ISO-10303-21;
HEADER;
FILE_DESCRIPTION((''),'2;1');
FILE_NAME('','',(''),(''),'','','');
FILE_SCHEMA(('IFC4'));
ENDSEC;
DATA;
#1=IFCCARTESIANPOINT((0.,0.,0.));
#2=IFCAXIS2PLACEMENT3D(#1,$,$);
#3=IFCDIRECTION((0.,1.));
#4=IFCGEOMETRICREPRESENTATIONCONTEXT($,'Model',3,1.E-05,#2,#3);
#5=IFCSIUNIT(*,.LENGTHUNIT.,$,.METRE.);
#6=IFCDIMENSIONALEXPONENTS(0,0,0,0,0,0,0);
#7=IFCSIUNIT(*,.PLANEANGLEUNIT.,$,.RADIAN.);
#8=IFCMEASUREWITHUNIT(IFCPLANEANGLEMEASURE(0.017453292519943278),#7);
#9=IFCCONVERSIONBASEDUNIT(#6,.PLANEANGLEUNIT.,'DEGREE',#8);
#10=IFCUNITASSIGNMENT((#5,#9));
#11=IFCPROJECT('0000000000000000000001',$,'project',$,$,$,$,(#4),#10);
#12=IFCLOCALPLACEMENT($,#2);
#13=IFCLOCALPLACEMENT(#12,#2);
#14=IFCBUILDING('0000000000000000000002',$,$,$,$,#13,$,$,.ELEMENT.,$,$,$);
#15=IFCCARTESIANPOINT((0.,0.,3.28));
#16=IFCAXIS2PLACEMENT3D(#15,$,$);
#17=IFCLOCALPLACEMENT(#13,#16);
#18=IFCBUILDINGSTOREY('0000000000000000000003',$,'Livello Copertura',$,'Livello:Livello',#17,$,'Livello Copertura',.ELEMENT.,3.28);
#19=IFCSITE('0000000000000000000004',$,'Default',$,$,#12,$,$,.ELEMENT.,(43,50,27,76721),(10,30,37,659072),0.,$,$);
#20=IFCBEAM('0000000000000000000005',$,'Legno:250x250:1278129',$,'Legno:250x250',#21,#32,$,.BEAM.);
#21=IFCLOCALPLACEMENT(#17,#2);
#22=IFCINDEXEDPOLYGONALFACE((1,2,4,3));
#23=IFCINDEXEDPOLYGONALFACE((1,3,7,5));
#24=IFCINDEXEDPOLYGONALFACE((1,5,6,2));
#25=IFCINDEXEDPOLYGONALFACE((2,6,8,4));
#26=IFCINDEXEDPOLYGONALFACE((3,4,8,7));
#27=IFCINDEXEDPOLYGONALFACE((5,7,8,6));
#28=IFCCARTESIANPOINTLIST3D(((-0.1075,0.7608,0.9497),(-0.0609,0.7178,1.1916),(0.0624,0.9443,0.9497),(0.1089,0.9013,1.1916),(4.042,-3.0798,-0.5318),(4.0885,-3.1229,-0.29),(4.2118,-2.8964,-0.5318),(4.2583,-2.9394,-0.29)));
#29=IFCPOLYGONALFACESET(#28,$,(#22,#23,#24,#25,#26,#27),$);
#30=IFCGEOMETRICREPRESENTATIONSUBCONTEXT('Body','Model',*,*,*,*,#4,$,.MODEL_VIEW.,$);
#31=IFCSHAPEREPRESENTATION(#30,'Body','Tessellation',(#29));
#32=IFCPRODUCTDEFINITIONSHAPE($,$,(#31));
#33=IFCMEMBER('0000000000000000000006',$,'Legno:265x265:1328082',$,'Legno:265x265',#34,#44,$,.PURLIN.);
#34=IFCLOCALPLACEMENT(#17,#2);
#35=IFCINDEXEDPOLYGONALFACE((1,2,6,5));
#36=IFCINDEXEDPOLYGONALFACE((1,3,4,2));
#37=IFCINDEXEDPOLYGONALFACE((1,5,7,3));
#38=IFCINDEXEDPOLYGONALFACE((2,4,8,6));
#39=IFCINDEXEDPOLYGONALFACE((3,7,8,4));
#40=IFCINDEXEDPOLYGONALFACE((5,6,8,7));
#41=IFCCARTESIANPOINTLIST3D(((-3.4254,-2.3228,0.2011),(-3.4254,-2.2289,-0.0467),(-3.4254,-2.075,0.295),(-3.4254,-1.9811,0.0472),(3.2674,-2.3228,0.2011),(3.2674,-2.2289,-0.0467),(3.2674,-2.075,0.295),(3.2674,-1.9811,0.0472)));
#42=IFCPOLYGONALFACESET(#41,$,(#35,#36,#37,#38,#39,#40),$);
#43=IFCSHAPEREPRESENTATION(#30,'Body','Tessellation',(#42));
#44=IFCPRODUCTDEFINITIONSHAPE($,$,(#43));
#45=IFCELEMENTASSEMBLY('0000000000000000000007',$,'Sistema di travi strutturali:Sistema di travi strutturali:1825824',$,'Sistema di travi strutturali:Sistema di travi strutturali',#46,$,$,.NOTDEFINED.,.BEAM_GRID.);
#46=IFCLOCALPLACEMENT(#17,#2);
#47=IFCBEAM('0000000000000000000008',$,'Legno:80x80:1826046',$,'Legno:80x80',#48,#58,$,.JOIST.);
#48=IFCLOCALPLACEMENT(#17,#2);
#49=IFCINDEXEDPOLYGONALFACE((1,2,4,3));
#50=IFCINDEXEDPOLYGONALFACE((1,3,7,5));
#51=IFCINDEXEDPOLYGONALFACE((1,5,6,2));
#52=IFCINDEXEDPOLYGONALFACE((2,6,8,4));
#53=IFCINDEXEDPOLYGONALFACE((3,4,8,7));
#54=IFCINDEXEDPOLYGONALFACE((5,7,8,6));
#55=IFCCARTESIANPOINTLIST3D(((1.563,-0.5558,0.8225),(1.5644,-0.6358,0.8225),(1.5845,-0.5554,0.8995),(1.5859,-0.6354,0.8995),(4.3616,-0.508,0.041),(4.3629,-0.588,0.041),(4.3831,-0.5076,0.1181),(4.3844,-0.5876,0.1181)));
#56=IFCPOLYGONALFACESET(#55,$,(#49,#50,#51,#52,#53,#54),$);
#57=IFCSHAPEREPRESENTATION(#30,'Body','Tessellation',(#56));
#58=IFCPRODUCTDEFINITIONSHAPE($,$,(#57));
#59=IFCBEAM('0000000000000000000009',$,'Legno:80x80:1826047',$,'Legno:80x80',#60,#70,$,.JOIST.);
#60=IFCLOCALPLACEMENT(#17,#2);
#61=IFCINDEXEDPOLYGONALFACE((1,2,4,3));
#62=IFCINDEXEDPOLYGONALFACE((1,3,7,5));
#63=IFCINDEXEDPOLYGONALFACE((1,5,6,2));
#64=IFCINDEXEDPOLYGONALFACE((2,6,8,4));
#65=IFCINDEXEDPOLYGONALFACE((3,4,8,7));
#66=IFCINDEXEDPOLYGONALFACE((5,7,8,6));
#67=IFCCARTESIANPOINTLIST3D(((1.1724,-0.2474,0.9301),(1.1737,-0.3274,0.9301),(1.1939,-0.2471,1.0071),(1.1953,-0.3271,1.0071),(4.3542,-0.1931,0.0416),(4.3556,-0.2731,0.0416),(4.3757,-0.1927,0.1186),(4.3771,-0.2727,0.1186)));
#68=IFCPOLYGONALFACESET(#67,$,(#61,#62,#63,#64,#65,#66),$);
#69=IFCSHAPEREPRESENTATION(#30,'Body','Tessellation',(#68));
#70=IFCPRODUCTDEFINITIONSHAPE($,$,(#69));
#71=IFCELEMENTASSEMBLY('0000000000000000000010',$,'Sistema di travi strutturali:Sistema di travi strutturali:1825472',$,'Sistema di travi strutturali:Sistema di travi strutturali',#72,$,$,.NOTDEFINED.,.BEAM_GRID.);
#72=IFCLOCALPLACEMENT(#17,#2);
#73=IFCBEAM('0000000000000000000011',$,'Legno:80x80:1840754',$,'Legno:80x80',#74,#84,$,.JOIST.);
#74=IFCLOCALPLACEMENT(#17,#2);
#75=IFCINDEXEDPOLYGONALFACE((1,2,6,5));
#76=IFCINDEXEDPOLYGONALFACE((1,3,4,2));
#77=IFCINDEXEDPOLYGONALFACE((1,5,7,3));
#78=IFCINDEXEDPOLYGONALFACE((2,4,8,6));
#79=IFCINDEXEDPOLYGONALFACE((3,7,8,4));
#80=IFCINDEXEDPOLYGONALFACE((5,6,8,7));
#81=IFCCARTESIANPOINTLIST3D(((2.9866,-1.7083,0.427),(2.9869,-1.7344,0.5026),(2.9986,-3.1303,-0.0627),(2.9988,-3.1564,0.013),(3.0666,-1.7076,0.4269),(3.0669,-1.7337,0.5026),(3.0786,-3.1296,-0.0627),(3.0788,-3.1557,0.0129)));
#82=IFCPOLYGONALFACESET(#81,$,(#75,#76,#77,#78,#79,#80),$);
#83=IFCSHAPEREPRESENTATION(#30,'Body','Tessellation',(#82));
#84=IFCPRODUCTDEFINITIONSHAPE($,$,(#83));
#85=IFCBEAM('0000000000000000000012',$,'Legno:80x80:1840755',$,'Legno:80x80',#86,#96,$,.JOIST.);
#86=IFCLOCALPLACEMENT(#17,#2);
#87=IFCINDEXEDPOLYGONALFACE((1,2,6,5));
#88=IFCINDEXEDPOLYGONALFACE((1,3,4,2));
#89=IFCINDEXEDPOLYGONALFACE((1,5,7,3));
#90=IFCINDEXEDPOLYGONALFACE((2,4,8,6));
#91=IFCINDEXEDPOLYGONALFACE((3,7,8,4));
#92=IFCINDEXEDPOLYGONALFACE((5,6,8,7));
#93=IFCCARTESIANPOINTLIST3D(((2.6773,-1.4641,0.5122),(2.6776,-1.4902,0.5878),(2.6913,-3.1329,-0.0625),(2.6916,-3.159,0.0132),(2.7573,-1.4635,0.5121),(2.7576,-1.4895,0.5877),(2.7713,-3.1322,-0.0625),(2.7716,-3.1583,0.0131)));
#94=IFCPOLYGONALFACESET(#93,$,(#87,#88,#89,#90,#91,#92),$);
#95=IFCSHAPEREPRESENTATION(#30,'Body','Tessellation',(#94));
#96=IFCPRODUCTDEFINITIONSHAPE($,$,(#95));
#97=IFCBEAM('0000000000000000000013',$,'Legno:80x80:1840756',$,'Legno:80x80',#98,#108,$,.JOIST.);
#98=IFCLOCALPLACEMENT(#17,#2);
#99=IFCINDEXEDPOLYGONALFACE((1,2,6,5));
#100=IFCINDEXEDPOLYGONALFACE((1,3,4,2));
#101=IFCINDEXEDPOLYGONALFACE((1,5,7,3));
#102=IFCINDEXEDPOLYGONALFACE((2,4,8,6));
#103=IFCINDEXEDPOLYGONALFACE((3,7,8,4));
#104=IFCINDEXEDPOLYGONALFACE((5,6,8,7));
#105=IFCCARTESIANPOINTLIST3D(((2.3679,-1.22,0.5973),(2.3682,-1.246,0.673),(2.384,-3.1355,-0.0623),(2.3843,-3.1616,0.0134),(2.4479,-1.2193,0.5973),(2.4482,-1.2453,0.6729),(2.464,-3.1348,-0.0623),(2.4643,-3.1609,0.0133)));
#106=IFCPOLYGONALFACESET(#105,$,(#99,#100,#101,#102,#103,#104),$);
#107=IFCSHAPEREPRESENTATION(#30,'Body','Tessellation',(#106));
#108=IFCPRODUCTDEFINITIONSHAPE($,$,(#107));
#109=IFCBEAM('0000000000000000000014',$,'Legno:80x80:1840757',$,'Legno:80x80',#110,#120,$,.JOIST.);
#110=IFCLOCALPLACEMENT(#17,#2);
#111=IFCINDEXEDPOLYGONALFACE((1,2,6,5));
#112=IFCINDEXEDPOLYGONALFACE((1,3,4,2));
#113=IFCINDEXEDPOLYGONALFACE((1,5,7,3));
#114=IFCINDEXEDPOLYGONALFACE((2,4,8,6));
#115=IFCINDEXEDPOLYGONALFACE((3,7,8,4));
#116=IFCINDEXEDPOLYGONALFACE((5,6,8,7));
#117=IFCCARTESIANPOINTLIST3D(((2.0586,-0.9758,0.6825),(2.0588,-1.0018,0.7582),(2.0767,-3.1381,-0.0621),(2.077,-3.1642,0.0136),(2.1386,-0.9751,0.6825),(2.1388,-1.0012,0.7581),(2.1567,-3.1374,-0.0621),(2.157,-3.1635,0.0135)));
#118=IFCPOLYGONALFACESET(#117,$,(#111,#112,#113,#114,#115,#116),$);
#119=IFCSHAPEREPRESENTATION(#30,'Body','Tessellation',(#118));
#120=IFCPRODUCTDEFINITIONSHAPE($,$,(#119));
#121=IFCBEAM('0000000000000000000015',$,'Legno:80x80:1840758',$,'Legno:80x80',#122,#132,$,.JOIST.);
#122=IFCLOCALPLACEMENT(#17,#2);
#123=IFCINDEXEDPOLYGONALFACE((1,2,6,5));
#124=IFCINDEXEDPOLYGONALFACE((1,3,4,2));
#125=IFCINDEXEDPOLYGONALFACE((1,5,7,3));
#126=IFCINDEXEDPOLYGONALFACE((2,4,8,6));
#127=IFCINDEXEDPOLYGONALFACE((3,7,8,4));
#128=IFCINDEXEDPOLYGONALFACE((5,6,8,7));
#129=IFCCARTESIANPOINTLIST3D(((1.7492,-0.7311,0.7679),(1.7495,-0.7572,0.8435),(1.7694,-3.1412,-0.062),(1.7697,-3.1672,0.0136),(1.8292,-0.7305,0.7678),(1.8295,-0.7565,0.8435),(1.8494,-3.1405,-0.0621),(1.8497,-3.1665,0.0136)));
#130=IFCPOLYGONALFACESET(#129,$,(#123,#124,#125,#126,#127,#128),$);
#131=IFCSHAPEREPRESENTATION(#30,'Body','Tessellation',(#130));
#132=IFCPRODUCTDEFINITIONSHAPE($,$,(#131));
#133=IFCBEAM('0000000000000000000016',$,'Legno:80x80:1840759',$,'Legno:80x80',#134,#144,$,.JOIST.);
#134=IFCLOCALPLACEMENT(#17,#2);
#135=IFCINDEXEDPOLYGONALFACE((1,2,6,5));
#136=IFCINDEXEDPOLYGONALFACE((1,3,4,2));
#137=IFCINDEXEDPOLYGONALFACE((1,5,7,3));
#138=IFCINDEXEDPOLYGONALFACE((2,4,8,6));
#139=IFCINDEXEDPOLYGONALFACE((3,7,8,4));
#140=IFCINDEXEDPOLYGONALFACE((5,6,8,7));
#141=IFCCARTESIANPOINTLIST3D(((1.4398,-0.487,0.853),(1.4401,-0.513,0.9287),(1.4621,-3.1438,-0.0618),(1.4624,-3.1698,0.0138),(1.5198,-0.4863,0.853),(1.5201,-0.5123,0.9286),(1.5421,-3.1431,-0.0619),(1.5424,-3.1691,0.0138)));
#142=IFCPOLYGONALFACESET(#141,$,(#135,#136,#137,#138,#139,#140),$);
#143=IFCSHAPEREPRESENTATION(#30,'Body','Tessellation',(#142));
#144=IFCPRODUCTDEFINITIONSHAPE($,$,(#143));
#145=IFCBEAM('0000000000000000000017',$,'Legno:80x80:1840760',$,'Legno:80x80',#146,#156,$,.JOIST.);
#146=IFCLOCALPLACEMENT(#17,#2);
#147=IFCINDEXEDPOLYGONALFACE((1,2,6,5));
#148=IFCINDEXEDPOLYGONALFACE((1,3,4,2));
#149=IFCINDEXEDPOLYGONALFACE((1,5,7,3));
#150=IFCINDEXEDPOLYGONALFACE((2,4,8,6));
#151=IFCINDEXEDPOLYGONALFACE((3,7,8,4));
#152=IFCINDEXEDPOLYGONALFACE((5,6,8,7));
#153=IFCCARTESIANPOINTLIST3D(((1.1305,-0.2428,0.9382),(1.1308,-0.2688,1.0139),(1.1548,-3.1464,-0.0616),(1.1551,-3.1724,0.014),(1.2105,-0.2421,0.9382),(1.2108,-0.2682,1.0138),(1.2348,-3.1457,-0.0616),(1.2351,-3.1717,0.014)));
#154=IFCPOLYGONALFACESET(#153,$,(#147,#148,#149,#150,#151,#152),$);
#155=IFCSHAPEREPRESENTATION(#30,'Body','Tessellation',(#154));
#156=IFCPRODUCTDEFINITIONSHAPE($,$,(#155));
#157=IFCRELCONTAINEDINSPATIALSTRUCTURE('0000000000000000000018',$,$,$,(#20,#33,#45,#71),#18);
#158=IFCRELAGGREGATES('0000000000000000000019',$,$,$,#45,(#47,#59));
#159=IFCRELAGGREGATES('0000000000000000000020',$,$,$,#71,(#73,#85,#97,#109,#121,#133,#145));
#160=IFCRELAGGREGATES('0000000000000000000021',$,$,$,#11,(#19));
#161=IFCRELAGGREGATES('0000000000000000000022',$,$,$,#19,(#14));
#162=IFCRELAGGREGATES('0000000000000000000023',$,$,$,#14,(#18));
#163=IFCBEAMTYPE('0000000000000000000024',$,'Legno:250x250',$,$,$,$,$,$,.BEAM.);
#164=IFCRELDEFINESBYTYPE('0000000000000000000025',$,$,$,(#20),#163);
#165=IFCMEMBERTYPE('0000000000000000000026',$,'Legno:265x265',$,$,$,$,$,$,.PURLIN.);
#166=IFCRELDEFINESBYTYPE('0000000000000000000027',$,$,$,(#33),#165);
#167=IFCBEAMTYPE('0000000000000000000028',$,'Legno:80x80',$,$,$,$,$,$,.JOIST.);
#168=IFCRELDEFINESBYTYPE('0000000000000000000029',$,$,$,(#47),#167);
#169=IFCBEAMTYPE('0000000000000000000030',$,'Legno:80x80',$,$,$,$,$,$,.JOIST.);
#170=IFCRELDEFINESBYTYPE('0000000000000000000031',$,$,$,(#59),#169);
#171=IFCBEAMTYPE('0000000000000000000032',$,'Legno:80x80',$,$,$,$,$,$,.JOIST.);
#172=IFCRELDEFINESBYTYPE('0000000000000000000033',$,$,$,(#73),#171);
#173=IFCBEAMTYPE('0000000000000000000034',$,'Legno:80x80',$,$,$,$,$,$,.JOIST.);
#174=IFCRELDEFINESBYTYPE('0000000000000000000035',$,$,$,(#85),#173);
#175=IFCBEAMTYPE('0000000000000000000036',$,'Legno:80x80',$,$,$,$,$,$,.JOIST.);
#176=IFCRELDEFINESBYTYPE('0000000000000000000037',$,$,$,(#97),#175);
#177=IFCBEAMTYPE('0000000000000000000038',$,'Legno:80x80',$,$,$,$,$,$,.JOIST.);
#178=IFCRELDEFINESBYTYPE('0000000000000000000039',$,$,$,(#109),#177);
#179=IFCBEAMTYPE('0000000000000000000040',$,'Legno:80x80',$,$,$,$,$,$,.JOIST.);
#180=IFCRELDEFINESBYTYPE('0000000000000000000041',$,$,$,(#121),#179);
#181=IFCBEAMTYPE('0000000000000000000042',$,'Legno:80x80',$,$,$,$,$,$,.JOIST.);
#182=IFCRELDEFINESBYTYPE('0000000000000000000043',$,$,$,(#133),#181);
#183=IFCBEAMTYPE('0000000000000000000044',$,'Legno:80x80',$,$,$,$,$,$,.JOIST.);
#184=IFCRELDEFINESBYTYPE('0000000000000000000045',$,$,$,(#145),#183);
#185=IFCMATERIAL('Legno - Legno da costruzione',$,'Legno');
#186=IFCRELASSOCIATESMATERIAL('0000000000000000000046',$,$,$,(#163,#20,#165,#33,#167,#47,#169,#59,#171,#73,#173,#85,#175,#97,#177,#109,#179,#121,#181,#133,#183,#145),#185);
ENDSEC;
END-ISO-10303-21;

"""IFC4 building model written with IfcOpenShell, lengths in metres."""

from ifc_helpers import new_model, entity, si_unit, converted_unit, direction, frame, origin, place, context, subcontext, project, spatial, indexed_curve, outline, extrude, source, transform, mapped, material, type_object, type_shapes, element, aggregate, save


model = new_model("IFC4")

# Units and contexts
model_context = context("Model", 3, precision=1e-05, world=origin(), true_north=direction((0.0, 1.0)))
body_context = subcontext(model_context, "Body", "Model", "MODEL_VIEW")
ifc_project = project(units=[si_unit("LENGTHUNIT", "METRE"), converted_unit("PLANEANGLEUNIT", "DEGREE", entity("IfcPlaneAngleMeasure", 0.017453292519943278), si_unit("PLANEANGLEUNIT", "RADIAN"), dimensions=[0, 0, 0, 0, 0, 0, 0])], contexts=[model_context])

# Site, building, storey
site_placement = place(None, origin())
site = spatial("IfcSite", under=ifc_project, at=site_placement, Name="Default", CompositionType="ELEMENT", RefLatitude=(43, 50, 27, 76721), RefLongitude=(10, 30, 37, 659072), RefElevation=0.0)
building_placement = place(site_placement, origin())
building = spatial("IfcBuilding", under=site, at=building_placement, CompositionType="ELEMENT")
storey_placement = place(building_placement, frame((0.0, 0.0, 3.28)))
storey = spatial("IfcBuildingStorey", under=building, at=storey_placement, Name="Livello Copertura", ObjectType="Livello:Livello", LongName="Livello Copertura", CompositionType="ELEMENT", Elevation=3.28)

# Beam
ifc_material = material(Name="Legno - Legno da costruzione", Category="Legno")
beam_type_1 = type_object("IfcBeamType", Name="Legno:250x250", PredefinedType="BEAM", material=ifc_material)
shared_shape_1 = source(origin(), body_context, "Body", "SweptSolid", [
    extrude(outline(indexed_curve([(-2.9225, -0.125), (2.9225, -0.125), (2.9225, 0.125), (-2.9225, 0.125), (-2.9225, -0.125)], self_intersect=False)), frame((-0.0935, 0.0, -0.125), z_axis=(0.0, 0.0, 1.0), x_axis=(-1.0, 0.0, 0.0)), (0.0, 0.0, 1.0), 0.25),
])
type_shapes(beam_type_1, [shared_shape_1])
beam_1_placement = place(storey_placement, frame((2.0091, -1.0279, 0.3536), z_axis=(0.18602, -0.172176, 0.967343), x_axis=(-0.70992, 0.657089, 0.253472)))
element("IfcBeam", 1, at=beam_1_placement, inside=storey, type_object=beam_type_1, material=ifc_material, Name="Legno:250x250:1278129", ObjectType="Legno:250x250", PredefinedType="BEAM", context=body_context, shape_type="MappedRepresentation", body=[
    mapped(shared_shape_1, transform((0.0, 0.0, 0.0), scale=1.0)),
])

# Member
member_type = type_object("IfcMemberType", Name="Legno:265x265", PredefinedType="PURLIN", material=ifc_material)
shared_shape_2 = source(origin(), body_context, "Body", "SweptSolid", [
    extrude(outline(indexed_curve([(-3.3464, -0.1325), (3.3464, -0.1325), (3.3464, 0.1325), (-3.3464, 0.1325), (-3.3464, -0.1325)], self_intersect=False)), frame((0.0182, 0.0, -0.1325), z_axis=(0.0, 0.0, 1.0), x_axis=(-1.0, 0.0, 0.0)), (0.0, 0.0, 1.0), 0.265),
])
type_shapes(member_type, [shared_shape_2])
member_placement = place(storey_placement, frame((-0.0972, -2.152, 0.1242), z_axis=(0.0, -0.354291, 0.935135), x_axis=(1.0, 0.0, 0.0)))
element("IfcMember", 2, at=member_placement, inside=storey, type_object=member_type, material=ifc_material, Name="Legno:265x265:1328082", ObjectType="Legno:265x265", PredefinedType="PURLIN", context=body_context, shape_type="MappedRepresentation", body=[
    mapped(shared_shape_2, transform((0.0, 0.0, 0.0), scale=1.0)),
])

# Element assemblies, beams
assembly_1_placement = place(storey_placement, origin())
assembly_1 = element("IfcElementAssembly", 3, at=assembly_1_placement, inside=storey, Name="Sistema di travi strutturali:Sistema di travi strutturali:1825824", ObjectType="Sistema di travi strutturali:Sistema di travi strutturali", AssemblyPlace="NOTDEFINED", PredefinedType="BEAM_GRID")
beam_type_2 = type_object("IfcBeamType", Name="Legno:80x80", PredefinedType="JOIST", material=ifc_material)
shared_shape_3 = source(origin(), body_context, "Body", "SweptSolid", [
    extrude(outline(indexed_curve([(-1.453, -0.04), (1.453, -0.04), (1.453, 0.04), (-1.453, 0.04), (-1.453, -0.04)], self_intersect=False)), frame((0.0, 0.0, -0.04), z_axis=(0.0, 0.0, 1.0), x_axis=(-1.0, 0.0, 0.0)), (0.0, 0.0, 1.0), 0.08),
])
type_shapes(beam_type_2, [shared_shape_3])
beam_2_placement = place(assembly_1_placement, frame((2.9737, -0.5717, 0.4703), z_axis=(0.268881, 0.004594, 0.963163), x_axis=(-0.963022, -0.016456, 0.26892)))
beam_2 = element("IfcBeam", 4, at=beam_2_placement, type_object=beam_type_2, material=ifc_material, Name="Legno:80x80:1826046", ObjectType="Legno:80x80", PredefinedType="JOIST", context=body_context, shape_type="MappedRepresentation", body=[
    mapped(shared_shape_3, transform((0.0, 0.0, 0.0), scale=1.0)),
])
beam_type_3 = type_object("IfcBeamType", Name="Legno:80x80", PredefinedType="JOIST", material=ifc_material)
shared_shape_4 = source(origin(), body_context, "Body", "SweptSolid", [
    extrude(outline(indexed_curve([(-1.652, -0.04), (1.652, -0.04), (1.652, 0.04), (-1.652, 0.04), (-1.652, -0.04)], self_intersect=False)), frame((0.0, 0.0, -0.04), z_axis=(0.0, 0.0, 1.0), x_axis=(-1.0, 0.0, 0.0)), (0.0, 0.0, 1.0), 0.08),
])
type_shapes(beam_type_3, [shared_shape_4])
beam_3_placement = place(assembly_1_placement, frame((2.7747, -0.2601, 0.5243), z_axis=(0.268881, 0.004594, 0.963163), x_axis=(-0.963022, -0.016456, 0.26892)))
beam_3 = element("IfcBeam", 5, at=beam_3_placement, type_object=beam_type_3, material=ifc_material, Name="Legno:80x80:1826047", ObjectType="Legno:80x80", PredefinedType="JOIST", context=body_context, shape_type="MappedRepresentation", body=[
    mapped(shared_shape_4, transform((0.0, 0.0, 0.0), scale=1.0)),
])
aggregate(assembly_1, [beam_2, beam_3])
assembly_2_placement = place(storey_placement, origin())
assembly_2 = element("IfcElementAssembly", 6, at=assembly_2_placement, inside=storey, Name="Sistema di travi strutturali:Sistema di travi strutturali:1825472", ObjectType="Sistema di travi strutturali:Sistema di travi strutturali", AssemblyPlace="NOTDEFINED", PredefinedType="BEAM_GRID")
beam_type_4 = type_object("IfcBeamType", Name="Legno:80x80", PredefinedType="JOIST", material=ifc_material)
shared_shape_5 = source(origin(), body_context, "Body", "SweptSolid", [
    extrude(outline(indexed_curve([(-0.752, -0.04), (0.752, -0.04), (0.752, 0.04), (-0.752, 0.04), (-0.752, -0.04)], self_intersect=False)), frame((0.0, 0.0, -0.04), z_axis=(0.0, 0.0, 1.0), x_axis=(-1.0, 0.0, 0.0)), (0.0, 0.0, 1.0), 0.08),
])
type_shapes(beam_type_4, [shared_shape_5])
beam_4_placement = place(assembly_2_placement, frame((3.0327, -2.432, 0.2199), z_axis=(0.003393, -0.32555, 0.945519), x_axis=(-0.007932, 0.945486, 0.325568)))
beam_4 = element("IfcBeam", 7, at=beam_4_placement, type_object=beam_type_4, material=ifc_material, Name="Legno:80x80:1840754", ObjectType="Legno:80x80", PredefinedType="JOIST", context=body_context, shape_type="MappedRepresentation", body=[
    mapped(shared_shape_5, transform((0.0, 0.0, 0.0), scale=1.0)),
])
beam_type_5 = type_object("IfcBeamType", Name="Legno:80x80", PredefinedType="JOIST", material=ifc_material)
shared_shape_6 = source(origin(), body_context, "Body", "SweptSolid", [
    extrude(outline(indexed_curve([(-0.8825, -0.04), (0.8825, -0.04), (0.8825, 0.04), (-0.8825, 0.04), (-0.8825, -0.04)], self_intersect=False)), frame((0.0, 0.0, -0.04), z_axis=(0.0, 0.0, 1.0), x_axis=(-1.0, 0.0, 0.0)), (0.0, 0.0, 1.0), 0.08),
])
type_shapes(beam_type_5, [shared_shape_6])
beam_5_placement = place(assembly_2_placement, frame((2.7244, -2.3112, 0.2626), z_axis=(0.003393, -0.32555, 0.945519), x_axis=(-0.007932, 0.945486, 0.325568)))
beam_5 = element("IfcBeam", 8, at=beam_5_placement, type_object=beam_type_5, material=ifc_material, Name="Legno:80x80:1840755", ObjectType="Legno:80x80", PredefinedType="JOIST", context=body_context, shape_type="MappedRepresentation", body=[
    mapped(shared_shape_6, transform((0.0, 0.0, 0.0), scale=1.0)),
])
beam_type_6 = type_object("IfcBeamType", Name="Legno:80x80", PredefinedType="JOIST", material=ifc_material)
shared_shape_7 = source(origin(), body_context, "Body", "SweptSolid", [
    extrude(outline(indexed_curve([(-1.013, -0.04), (1.013, -0.04), (1.013, 0.04), (-1.013, 0.04), (-1.013, -0.04)], self_intersect=False)), frame((0.0, 0.0, -0.04), z_axis=(0.0, 0.0, 1.0), x_axis=(-1.0, 0.0, 0.0)), (0.0, 0.0, 1.0), 0.08),
])
type_shapes(beam_type_6, [shared_shape_7])
beam_6_placement = place(assembly_2_placement, frame((2.4161, -2.1904, 0.3053), z_axis=(0.003393, -0.32555, 0.945519), x_axis=(-0.007932, 0.945486, 0.325568)))
beam_6 = element("IfcBeam", 9, at=beam_6_placement, type_object=beam_type_6, material=ifc_material, Name="Legno:80x80:1840756", ObjectType="Legno:80x80", PredefinedType="JOIST", context=body_context, shape_type="MappedRepresentation", body=[
    mapped(shared_shape_7, transform((0.0, 0.0, 0.0), scale=1.0)),
])
beam_type_7 = type_object("IfcBeamType", Name="Legno:80x80", PredefinedType="JOIST", material=ifc_material)
shared_shape_8 = source(origin(), body_context, "Body", "SweptSolid", [
    extrude(outline(indexed_curve([(-1.1435, -0.04), (1.1435, -0.04), (1.1435, 0.04), (-1.1435, 0.04), (-1.1435, -0.04)], self_intersect=False)), frame((0.0, 0.0, -0.04), z_axis=(0.0, 0.0, 1.0), x_axis=(-1.0, 0.0, 0.0)), (0.0, 0.0, 1.0), 0.08),
])
type_shapes(beam_type_7, [shared_shape_8])
beam_7_placement = place(assembly_2_placement, frame((2.1078, -2.0696, 0.348), z_axis=(0.003393, -0.32555, 0.945519), x_axis=(-0.007932, 0.945486, 0.325568)))
beam_7 = element("IfcBeam", 10, at=beam_7_placement, type_object=beam_type_7, material=ifc_material, Name="Legno:80x80:1840757", ObjectType="Legno:80x80", PredefinedType="JOIST", context=body_context, shape_type="MappedRepresentation", body=[
    mapped(shared_shape_8, transform((0.0, 0.0, 0.0), scale=1.0)),
])
beam_type_8 = type_object("IfcBeamType", Name="Legno:80x80", PredefinedType="JOIST", material=ifc_material)
shared_shape_9 = source(origin(), body_context, "Body", "SweptSolid", [
    extrude(outline(indexed_curve([(-1.2745, -0.04), (1.2745, -0.04), (1.2745, 0.04), (-1.2745, 0.04), (-1.2745, -0.04)], self_intersect=False)), frame((0.0, 0.0, -0.04), z_axis=(0.0, 0.0, 1.0), x_axis=(-1.0, 0.0, 0.0)), (0.0, 0.0, 1.0), 0.08),
])
type_shapes(beam_type_8, [shared_shape_9])
beam_8_placement = place(assembly_2_placement, frame((1.7994, -1.9488, 0.3907), z_axis=(0.003393, -0.32555, 0.945519), x_axis=(-0.007932, 0.945486, 0.325568)))
beam_8 = element("IfcBeam", 11, at=beam_8_placement, type_object=beam_type_8, material=ifc_material, Name="Legno:80x80:1840758", ObjectType="Legno:80x80", PredefinedType="JOIST", context=body_context, shape_type="MappedRepresentation", body=[
    mapped(shared_shape_9, transform((0.0, 0.0, 0.0), scale=1.0)),
])
beam_type_9 = type_object("IfcBeamType", Name="Legno:80x80", PredefinedType="JOIST", material=ifc_material)
shared_shape_10 = source(origin(), body_context, "Body", "SweptSolid", [
    extrude(outline(indexed_curve([(-1.405, -0.04), (1.405, -0.04), (1.405, 0.04), (-1.405, 0.04), (-1.405, -0.04)], self_intersect=False)), frame((0.0, 0.0, -0.04), z_axis=(0.0, 0.0, 1.0), x_axis=(-1.0, 0.0, 0.0)), (0.0, 0.0, 1.0), 0.08),
])
type_shapes(beam_type_9, [shared_shape_10])
beam_9_placement = place(assembly_2_placement, frame((1.4911, -1.8281, 0.4334), z_axis=(0.003393, -0.32555, 0.945519), x_axis=(-0.007932, 0.945486, 0.325568)))
beam_9 = element("IfcBeam", 12, at=beam_9_placement, type_object=beam_type_9, material=ifc_material, Name="Legno:80x80:1840759", ObjectType="Legno:80x80", PredefinedType="JOIST", context=body_context, shape_type="MappedRepresentation", body=[
    mapped(shared_shape_10, transform((0.0, 0.0, 0.0), scale=1.0)),
])
beam_type_10 = type_object("IfcBeamType", Name="Legno:80x80", PredefinedType="JOIST", material=ifc_material)
shared_shape_11 = source(origin(), body_context, "Body", "SweptSolid", [
    extrude(outline(indexed_curve([(-1.5355, -0.04), (1.5355, -0.04), (1.5355, 0.04), (-1.5355, 0.04), (-1.5355, -0.04)], self_intersect=False)), frame((0.0, 0.0, -0.04), z_axis=(0.0, 0.0, 1.0), x_axis=(-1.0, 0.0, 0.0)), (0.0, 0.0, 1.0), 0.08),
])
type_shapes(beam_type_10, [shared_shape_11])
beam_10_placement = place(assembly_2_placement, frame((1.1828, -1.7073, 0.4761), z_axis=(0.003393, -0.32555, 0.945519), x_axis=(-0.007932, 0.945486, 0.325568)))
beam_10 = element("IfcBeam", 13, at=beam_10_placement, type_object=beam_type_10, material=ifc_material, Name="Legno:80x80:1840760", ObjectType="Legno:80x80", PredefinedType="JOIST", context=body_context, shape_type="MappedRepresentation", body=[
    mapped(shared_shape_11, transform((0.0, 0.0, 0.0), scale=1.0)),
])
aggregate(assembly_2, [beam_4, beam_5, beam_6, beam_7, beam_8, beam_9, beam_10])

save(model, "model.ifc")
